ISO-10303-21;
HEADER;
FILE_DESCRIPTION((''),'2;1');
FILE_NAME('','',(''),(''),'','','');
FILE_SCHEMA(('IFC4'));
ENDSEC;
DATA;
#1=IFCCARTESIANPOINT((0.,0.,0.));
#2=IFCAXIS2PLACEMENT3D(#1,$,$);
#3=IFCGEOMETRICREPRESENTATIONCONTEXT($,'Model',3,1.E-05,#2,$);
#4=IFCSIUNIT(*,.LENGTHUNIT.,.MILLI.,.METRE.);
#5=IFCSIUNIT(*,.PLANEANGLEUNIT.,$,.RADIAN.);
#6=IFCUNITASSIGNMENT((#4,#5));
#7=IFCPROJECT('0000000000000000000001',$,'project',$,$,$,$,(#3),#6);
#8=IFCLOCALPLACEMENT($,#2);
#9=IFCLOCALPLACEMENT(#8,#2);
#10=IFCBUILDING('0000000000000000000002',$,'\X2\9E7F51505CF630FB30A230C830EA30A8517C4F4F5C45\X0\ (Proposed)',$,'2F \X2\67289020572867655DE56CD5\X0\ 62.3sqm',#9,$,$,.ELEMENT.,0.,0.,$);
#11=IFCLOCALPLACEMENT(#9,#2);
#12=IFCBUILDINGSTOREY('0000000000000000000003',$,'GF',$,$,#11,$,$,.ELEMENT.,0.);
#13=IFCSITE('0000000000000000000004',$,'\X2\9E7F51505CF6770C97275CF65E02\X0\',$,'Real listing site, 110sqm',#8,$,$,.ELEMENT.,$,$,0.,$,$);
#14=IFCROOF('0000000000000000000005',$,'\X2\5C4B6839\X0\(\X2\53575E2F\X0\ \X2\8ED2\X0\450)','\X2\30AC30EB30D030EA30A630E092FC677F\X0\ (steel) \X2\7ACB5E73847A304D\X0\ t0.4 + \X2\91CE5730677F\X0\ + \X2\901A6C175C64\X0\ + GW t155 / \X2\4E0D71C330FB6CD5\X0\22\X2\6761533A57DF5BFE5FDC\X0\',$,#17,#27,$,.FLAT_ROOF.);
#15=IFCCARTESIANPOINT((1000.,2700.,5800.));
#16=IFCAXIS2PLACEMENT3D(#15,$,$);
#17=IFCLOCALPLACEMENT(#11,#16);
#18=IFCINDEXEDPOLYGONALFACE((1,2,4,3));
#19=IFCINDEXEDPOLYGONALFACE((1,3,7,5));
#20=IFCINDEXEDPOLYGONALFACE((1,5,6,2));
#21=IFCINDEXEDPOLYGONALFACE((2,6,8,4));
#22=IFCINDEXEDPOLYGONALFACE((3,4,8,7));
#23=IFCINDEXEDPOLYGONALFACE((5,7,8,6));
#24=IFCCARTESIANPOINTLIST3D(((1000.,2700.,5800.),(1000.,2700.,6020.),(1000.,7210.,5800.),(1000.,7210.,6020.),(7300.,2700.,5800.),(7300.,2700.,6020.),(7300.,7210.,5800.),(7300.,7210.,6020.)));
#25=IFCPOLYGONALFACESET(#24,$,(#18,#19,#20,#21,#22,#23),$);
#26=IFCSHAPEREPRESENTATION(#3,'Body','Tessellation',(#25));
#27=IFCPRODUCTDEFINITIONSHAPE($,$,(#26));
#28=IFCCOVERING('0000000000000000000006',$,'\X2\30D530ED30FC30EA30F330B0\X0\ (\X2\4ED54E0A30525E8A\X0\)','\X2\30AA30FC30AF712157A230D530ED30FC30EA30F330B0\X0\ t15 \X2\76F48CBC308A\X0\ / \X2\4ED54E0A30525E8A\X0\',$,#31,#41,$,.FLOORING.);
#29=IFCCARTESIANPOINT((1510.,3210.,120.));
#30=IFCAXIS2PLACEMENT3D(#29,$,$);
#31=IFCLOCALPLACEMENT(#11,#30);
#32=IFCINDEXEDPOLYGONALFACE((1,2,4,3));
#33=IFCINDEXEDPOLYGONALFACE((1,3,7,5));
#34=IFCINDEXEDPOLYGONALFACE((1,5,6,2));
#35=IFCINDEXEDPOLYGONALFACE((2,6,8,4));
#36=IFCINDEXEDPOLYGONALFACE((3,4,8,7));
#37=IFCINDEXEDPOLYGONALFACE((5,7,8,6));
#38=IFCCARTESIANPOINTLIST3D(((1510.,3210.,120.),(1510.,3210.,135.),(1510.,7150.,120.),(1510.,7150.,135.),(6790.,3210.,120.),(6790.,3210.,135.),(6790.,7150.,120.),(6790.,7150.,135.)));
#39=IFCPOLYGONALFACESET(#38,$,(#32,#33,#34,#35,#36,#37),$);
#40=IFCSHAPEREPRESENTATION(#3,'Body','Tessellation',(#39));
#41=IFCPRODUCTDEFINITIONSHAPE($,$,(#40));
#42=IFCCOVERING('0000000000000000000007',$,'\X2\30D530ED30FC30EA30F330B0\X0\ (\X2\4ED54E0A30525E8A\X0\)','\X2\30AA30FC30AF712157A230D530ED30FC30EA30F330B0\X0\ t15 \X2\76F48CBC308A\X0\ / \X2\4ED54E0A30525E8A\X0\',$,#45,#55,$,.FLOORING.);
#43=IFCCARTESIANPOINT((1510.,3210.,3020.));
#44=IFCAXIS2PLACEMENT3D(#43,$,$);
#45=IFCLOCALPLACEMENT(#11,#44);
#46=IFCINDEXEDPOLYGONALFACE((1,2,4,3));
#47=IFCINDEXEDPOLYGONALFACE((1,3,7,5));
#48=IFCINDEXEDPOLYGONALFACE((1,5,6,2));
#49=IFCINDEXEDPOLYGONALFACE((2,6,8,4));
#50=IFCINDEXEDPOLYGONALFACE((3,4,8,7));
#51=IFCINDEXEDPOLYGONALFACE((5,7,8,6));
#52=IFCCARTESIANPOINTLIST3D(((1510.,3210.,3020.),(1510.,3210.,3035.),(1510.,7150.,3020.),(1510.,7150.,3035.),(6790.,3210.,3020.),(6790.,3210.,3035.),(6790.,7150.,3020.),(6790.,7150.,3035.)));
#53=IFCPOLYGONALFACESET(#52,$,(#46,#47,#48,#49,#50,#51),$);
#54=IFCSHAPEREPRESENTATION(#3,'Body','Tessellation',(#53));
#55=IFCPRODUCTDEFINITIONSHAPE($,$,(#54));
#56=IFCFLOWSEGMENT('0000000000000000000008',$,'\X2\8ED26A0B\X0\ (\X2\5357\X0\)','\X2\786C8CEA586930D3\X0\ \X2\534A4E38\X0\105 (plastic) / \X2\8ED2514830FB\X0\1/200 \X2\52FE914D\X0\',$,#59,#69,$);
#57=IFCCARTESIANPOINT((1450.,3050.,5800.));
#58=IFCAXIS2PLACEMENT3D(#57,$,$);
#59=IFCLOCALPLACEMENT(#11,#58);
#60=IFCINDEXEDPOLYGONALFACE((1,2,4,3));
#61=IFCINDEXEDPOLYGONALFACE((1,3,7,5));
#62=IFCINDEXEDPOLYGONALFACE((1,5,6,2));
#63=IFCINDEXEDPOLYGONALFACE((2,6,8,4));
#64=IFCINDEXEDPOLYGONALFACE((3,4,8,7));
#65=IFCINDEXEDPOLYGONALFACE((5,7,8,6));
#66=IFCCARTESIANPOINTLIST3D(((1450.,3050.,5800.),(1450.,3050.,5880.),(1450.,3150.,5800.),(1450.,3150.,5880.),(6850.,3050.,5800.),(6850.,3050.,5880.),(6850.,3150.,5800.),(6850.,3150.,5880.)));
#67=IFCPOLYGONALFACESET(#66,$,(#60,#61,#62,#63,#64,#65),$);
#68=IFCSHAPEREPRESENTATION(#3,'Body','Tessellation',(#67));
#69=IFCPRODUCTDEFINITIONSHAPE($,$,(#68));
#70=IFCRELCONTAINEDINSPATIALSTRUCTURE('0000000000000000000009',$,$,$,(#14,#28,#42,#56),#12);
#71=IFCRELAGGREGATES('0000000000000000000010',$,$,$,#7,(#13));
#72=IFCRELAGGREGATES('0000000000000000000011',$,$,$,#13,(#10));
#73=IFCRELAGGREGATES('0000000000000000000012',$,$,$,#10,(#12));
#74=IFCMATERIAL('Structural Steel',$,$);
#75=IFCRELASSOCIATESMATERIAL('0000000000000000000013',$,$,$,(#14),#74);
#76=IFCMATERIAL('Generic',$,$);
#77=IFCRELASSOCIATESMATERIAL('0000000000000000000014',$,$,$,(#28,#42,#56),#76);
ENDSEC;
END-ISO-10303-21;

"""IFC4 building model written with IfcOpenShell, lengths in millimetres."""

from ifc_helpers import new_model, si_unit, frame, frame_2d, origin, place, context, project, spatial, rectangle, extrude, material, element, save


model = new_model("IFC4")

# Units and contexts
model_context = context("Model", 3, precision=1e-05, world=origin())
ifc_project = project(units=[si_unit("LENGTHUNIT", "METRE", prefix="MILLI"), si_unit("PLANEANGLEUNIT", "RADIAN")], contexts=[model_context])

# Site, building, storey
site_placement = place(None, origin())
site = spatial("IfcSite", under=ifc_project, at=site_placement, Name="鹿児島県霧島市", ObjectType="Real listing site, 110sqm", CompositionType="ELEMENT", RefElevation=0.0)
building_placement = place(site_placement, origin())
building = spatial("IfcBuilding", under=site, at=building_placement, Name="鹿児島・アトリエ兼住居 (Proposed)", ObjectType="2F 木造在来工法 62.3sqm", CompositionType="ELEMENT", ElevationOfRefHeight=0.0, ElevationOfTerrain=0.0)
storey_placement = place(building_placement, origin())
storey = spatial("IfcBuildingStorey", under=building, at=storey_placement, Name="GF", CompositionType="ELEMENT", Elevation=0.0)

# Roof
ifc_material_1 = material(Name="Structural Steel")
for number, where, name in (
    (1, (1000.0, 2700.0, 5800.0), "屋根(南帯 軒450)"),
):
    element("IfcRoof", number, at=place(storey_placement, frame(where)), inside=storey, material=ifc_material_1, Name=name, Description="ガルバリウム鋼板 (steel) 立平葺き t0.4 + 野地板 + 通気層 + GW t155 / 不燃・法22条区域対応", PredefinedType="FLAT_ROOF", context=model_context, shape_type="SweptSolid", body=[
        extrude(rectangle(XDim=6300.0, YDim=4510.0, at=frame_2d((3150.0, 2255.0))), frame((1000.0, 2700.0, 5800.0)), (0.0, 0.0, 1.0), 220.0),
    ])

# Coverings
ifc_material_2 = material(Name="Generic")
covering_1_placement = place(storey_placement, frame((1510.0, 3210.0, 120.0)))
element("IfcCovering", 2, at=covering_1_placement, inside=storey, material=ifc_material_2, Name="フローリング (仕上げ床)", Description="オーク無垢フローリング t15 直貼り / 仕上げ床", PredefinedType="FLOORING", context=model_context, shape_type="SweptSolid", body=[
    extrude(rectangle(XDim=5280.0, YDim=3940.0, at=frame_2d((2640.0, 1970.0))), frame((1510.0, 3210.0, 120.0)), (0.0, 0.0, 1.0), 15.0),
])
covering_2_placement = place(storey_placement, frame((1510.0, 3210.0, 3020.0)))
element("IfcCovering", 3, at=covering_2_placement, inside=storey, material=ifc_material_2, Name="フローリング (仕上げ床)", Description="オーク無垢フローリング t15 直貼り / 仕上げ床", PredefinedType="FLOORING", context=model_context, shape_type="SweptSolid", body=[
    extrude(rectangle(XDim=5280.0, YDim=3940.0, at=frame_2d((2640.0, 1970.0))), frame((1510.0, 3210.0, 3020.0)), (0.0, 0.0, 1.0), 15.0),
])

# Flow segment
flow_segment_placement = place(storey_placement, frame((1450.0, 3050.0, 5800.0)))
element("IfcFlowSegment", 4, at=flow_segment_placement, inside=storey, material=ifc_material_2, Name="軒樋 (南)", Description="硬質塩ビ 半丸105 (plastic) / 軒先・1/200 勾配", context=model_context, shape_type="SweptSolid", body=[
    extrude(rectangle(XDim=5400.0, YDim=100.0, at=frame_2d((2700.0, 50.0))), frame((1450.0, 3050.0, 5800.0)), (0.0, 0.0, 1.0), 80.0),
])

save(model, "model.ifc")
